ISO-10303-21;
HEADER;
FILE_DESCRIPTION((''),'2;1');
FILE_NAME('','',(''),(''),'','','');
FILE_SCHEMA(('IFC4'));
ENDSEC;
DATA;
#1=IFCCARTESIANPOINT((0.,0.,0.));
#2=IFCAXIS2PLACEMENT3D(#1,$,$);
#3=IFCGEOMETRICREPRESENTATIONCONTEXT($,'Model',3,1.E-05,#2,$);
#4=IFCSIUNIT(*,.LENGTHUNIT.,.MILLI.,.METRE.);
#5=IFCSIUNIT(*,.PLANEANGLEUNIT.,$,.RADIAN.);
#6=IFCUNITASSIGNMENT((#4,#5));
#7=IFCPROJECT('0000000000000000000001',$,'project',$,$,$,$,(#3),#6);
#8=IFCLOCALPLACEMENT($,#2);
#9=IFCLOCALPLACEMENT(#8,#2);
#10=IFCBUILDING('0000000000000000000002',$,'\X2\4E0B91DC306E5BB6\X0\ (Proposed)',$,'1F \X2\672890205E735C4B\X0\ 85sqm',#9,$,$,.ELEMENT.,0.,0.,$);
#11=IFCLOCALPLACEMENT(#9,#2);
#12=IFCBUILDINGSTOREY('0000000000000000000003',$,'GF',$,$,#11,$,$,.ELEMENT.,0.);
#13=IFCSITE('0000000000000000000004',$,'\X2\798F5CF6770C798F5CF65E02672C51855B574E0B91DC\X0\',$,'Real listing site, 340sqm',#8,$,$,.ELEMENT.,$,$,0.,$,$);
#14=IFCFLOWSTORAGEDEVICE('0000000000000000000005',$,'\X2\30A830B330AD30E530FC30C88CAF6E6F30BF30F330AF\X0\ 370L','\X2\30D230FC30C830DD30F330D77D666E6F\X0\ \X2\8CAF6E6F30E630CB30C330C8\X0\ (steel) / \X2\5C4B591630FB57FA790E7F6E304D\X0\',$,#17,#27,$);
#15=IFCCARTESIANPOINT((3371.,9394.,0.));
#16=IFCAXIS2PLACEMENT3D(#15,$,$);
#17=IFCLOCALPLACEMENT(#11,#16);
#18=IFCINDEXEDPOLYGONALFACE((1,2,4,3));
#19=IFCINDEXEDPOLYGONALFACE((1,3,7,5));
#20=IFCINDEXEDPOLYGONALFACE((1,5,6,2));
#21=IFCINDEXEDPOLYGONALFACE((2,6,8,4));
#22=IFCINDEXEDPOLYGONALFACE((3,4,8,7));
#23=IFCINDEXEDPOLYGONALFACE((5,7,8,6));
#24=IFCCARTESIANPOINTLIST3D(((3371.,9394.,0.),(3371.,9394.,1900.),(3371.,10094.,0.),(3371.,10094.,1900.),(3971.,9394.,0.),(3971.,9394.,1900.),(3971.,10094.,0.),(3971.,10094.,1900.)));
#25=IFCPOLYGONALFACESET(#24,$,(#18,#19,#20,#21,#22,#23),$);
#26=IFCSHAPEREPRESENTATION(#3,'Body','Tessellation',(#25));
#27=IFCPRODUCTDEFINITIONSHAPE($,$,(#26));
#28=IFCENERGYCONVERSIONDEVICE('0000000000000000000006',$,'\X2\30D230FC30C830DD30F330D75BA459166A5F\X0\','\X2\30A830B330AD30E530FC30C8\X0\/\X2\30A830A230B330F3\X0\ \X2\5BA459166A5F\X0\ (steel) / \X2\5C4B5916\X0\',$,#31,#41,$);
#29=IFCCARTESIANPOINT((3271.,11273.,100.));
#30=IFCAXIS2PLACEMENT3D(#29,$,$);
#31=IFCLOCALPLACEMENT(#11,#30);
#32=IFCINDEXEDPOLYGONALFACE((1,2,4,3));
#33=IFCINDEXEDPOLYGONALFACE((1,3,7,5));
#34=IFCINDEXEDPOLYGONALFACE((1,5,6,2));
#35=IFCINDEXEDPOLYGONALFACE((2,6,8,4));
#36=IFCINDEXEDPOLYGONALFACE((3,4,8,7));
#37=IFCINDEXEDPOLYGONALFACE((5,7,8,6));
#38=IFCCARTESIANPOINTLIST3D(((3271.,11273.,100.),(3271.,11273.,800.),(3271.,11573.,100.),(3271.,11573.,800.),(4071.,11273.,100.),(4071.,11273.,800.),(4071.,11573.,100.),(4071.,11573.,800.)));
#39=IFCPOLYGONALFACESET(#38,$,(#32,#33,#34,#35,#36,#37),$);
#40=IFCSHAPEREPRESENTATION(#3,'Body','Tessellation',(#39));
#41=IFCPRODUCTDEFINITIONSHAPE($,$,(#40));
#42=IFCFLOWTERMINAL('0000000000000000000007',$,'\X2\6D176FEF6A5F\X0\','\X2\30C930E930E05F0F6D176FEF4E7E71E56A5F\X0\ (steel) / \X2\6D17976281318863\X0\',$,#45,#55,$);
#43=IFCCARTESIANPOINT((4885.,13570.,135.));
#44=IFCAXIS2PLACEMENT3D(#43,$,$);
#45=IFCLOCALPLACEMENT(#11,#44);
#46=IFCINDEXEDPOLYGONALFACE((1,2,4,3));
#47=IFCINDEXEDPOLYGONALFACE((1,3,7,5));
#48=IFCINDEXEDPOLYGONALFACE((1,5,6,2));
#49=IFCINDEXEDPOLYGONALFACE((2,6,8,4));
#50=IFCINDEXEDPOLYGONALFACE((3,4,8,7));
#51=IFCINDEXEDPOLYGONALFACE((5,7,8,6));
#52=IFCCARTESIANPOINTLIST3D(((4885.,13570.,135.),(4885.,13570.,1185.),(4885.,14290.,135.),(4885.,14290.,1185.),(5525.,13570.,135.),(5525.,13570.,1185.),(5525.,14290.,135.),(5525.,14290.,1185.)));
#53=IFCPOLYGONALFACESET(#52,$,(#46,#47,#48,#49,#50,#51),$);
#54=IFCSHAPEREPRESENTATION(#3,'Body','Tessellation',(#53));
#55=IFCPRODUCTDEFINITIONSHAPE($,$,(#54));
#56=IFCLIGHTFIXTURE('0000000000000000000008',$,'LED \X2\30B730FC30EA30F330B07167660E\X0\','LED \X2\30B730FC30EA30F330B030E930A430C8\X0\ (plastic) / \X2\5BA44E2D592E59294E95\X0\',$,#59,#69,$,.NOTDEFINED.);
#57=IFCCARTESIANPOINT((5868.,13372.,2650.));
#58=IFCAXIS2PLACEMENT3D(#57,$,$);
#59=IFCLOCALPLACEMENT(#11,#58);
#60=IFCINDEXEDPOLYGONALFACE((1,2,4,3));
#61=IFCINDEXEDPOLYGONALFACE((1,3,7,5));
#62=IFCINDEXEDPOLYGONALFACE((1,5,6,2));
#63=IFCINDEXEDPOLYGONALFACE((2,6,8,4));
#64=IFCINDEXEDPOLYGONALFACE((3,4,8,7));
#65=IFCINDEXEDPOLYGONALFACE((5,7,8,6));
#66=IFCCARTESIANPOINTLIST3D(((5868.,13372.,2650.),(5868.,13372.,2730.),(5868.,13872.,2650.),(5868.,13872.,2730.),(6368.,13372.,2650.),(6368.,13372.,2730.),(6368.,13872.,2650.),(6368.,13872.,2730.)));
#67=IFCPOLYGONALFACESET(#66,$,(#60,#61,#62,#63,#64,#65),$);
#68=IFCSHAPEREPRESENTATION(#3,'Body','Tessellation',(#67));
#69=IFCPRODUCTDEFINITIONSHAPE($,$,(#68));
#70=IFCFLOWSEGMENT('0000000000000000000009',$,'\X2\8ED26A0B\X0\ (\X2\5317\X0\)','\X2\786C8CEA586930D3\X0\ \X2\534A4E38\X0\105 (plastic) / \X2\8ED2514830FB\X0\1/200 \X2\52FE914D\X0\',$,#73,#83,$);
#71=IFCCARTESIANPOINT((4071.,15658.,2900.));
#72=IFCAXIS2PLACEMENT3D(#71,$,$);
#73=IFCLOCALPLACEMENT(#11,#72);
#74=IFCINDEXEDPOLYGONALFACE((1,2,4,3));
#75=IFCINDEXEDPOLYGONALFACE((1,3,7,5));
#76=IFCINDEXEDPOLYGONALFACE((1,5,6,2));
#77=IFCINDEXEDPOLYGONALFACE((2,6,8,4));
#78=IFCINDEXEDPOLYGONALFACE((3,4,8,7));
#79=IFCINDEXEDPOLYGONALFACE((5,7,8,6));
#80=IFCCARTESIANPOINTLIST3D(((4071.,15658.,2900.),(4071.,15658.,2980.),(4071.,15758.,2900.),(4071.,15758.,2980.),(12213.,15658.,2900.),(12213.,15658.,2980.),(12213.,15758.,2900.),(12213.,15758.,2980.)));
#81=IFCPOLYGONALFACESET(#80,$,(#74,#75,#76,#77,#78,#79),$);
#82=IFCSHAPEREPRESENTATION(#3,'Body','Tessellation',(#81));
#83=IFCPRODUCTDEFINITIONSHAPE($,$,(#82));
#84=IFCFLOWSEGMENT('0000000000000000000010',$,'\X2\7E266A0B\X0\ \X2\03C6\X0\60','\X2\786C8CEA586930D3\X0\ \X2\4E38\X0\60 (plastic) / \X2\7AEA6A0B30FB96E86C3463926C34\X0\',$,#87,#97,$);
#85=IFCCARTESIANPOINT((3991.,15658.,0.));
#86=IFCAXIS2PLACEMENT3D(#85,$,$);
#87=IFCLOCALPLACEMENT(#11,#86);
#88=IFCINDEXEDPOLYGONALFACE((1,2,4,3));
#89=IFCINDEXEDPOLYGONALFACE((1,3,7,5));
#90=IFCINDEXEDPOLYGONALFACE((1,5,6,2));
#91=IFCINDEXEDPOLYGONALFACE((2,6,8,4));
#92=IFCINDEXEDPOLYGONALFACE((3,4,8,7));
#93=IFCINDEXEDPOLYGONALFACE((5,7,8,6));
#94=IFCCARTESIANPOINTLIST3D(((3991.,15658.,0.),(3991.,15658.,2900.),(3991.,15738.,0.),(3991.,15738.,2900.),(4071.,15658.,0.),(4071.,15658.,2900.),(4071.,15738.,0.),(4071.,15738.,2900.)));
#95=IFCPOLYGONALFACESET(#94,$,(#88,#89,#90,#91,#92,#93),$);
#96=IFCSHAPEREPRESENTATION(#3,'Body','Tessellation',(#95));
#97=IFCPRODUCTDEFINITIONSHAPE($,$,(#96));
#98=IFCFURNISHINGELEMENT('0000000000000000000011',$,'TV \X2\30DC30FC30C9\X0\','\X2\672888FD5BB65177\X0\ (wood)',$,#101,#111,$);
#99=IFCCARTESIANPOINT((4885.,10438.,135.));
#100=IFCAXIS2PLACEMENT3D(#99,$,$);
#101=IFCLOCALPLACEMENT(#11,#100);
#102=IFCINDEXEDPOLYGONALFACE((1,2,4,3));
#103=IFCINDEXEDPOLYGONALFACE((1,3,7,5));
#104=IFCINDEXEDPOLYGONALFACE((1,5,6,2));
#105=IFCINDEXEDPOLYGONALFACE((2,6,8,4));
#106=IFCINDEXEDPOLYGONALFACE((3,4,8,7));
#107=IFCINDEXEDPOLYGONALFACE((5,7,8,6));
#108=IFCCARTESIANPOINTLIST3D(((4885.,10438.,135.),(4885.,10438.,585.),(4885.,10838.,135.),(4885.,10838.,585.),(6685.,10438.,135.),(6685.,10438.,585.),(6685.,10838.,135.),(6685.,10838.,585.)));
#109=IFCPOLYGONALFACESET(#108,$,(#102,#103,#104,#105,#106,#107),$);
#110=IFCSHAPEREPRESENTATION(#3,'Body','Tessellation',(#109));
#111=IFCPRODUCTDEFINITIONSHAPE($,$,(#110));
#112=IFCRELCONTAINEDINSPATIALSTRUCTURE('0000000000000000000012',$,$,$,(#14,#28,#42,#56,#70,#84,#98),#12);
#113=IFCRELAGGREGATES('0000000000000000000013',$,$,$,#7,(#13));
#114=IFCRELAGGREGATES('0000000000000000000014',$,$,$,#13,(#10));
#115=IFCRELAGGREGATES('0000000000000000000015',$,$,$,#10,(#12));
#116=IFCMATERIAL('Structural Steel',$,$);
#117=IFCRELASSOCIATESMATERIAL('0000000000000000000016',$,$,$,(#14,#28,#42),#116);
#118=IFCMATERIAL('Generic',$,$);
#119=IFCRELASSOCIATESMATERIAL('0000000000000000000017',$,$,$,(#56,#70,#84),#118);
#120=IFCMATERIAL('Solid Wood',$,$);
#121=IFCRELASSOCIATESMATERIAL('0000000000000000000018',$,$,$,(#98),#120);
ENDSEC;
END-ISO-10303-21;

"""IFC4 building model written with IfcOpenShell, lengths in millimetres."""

from ifc_helpers import new_model, si_unit, frame, frame_2d, origin, place, context, project, spatial, rectangle, extrude, material, element, save


model = new_model("IFC4")

# Units and contexts
model_context = context("Model", 3, precision=1e-05, world=origin())
ifc_project = project(units=[si_unit("LENGTHUNIT", "METRE", prefix="MILLI"), si_unit("PLANEANGLEUNIT", "RADIAN")], contexts=[model_context])

# Site, building, storey
site_placement = place(None, origin())
site = spatial("IfcSite", under=ifc_project, at=site_placement, Name="福島県福島市本内字下釜", ObjectType="Real listing site, 340sqm", CompositionType="ELEMENT", RefElevation=0.0)
building_placement = place(site_placement, origin())
building = spatial("IfcBuilding", under=site, at=building_placement, Name="下釜の家 (Proposed)", ObjectType="1F 木造平屋 85sqm", CompositionType="ELEMENT", ElevationOfRefHeight=0.0, ElevationOfTerrain=0.0)
storey_placement = place(building_placement, origin())
storey = spatial("IfcBuildingStorey", under=building, at=storey_placement, Name="GF", CompositionType="ELEMENT", Elevation=0.0)

# Shared definitions
ifc_material_1 = material(Name="Solid Wood")

# Shared definitions
ifc_material_2 = material(Name="Structural Steel")

# Shared definitions
ifc_material_3 = material(Name="Generic")

# Flow storage device
flow_storage_device_placement = place(storey_placement, frame((3371.0, 9394.0, 0.0)))
element("IfcFlowStorageDevice", 1, at=flow_storage_device_placement, inside=storey, material=ifc_material_2, Name="エコキュート貯湯タンク 370L", Description="ヒートポンプ給湯 貯湯ユニット (steel) / 屋外・基礎置き", context=model_context, shape_type="SweptSolid", body=[
    extrude(rectangle(XDim=600.0, YDim=700.0, at=frame_2d((300.0, 350.0))), frame((3371.0, 9394.0, 0.0)), (0.0, 0.0, 1.0), 1900.0),
])

# Energy conversion device
energy_conversion_device_placement = place(storey_placement, frame((3271.0, 11273.0, 100.0)))
element("IfcEnergyConversionDevice", 2, at=energy_conversion_device_placement, inside=storey, material=ifc_material_2, Name="ヒートポンプ室外機", Description="エコキュート/エアコン 室外機 (steel) / 屋外", context=model_context, shape_type="SweptSolid", body=[
    extrude(rectangle(XDim=800.0, YDim=300.0, at=frame_2d((400.0, 150.0))), frame((3271.0, 11273.0, 100.0)), (0.0, 0.0, 1.0), 700.0),
])

# Flow terminal
flow_terminal_placement = place(storey_placement, frame((4885.0, 13570.0, 135.0)))
element("IfcFlowTerminal", 3, at=flow_terminal_placement, inside=storey, material=ifc_material_2, Name="洗濯機", Description="ドラム式洗濯乾燥機 (steel) / 洗面脱衣", context=model_context, shape_type="SweptSolid", body=[
    extrude(rectangle(XDim=640.0, YDim=720.0, at=frame_2d((320.0, 360.0))), frame((4885.0, 13570.0, 135.0)), (0.0, 0.0, 1.0), 1050.0),
])

# Light fixture
light_fixture_placement = place(storey_placement, frame((5868.0, 13372.0, 2650.0)))
element("IfcLightFixture", 4, at=light_fixture_placement, inside=storey, material=ifc_material_3, Name="LED シーリング照明", Description="LED シーリングライト (plastic) / 室中央天井", PredefinedType="NOTDEFINED", context=model_context, shape_type="SweptSolid", body=[
    extrude(rectangle(XDim=500.0, YDim=500.0, at=frame_2d((250.0, 250.0))), frame((5868.0, 13372.0, 2650.0)), (0.0, 0.0, 1.0), 80.0),
])

# Flow segments
flow_segment_1_placement = place(storey_placement, frame((4071.0, 15658.0, 2900.0)))
element("IfcFlowSegment", 5, at=flow_segment_1_placement, inside=storey, material=ifc_material_3, Name="軒樋 (北)", Description="硬質塩ビ 半丸105 (plastic) / 軒先・1/200 勾配", context=model_context, shape_type="SweptSolid", body=[
    extrude(rectangle(XDim=8142.0, YDim=100.0, at=frame_2d((4071.0, 50.0))), frame((4071.0, 15658.0, 2900.0)), (0.0, 0.0, 1.0), 80.0),
])
flow_segment_2_placement = place(storey_placement, frame((3991.0, 15658.0, 0.0)))
element("IfcFlowSegment", 6, at=flow_segment_2_placement, inside=storey, material=ifc_material_3, Name="縦樋 φ60", Description="硬質塩ビ 丸60 (plastic) / 竪樋・雨水排水", context=model_context, shape_type="SweptSolid", body=[
    extrude(rectangle(XDim=80.0, YDim=80.0, at=frame_2d((40.0, 40.0))), frame((3991.0, 15658.0, 0.0)), (0.0, 0.0, 1.0), 2900.0),
])

# Furnishing element
furnishing_placement = place(storey_placement, frame((4885.0, 10438.0, 135.0)))
element("IfcFurnishingElement", 7, at=furnishing_placement, inside=storey, material=ifc_material_1, Name="TV ボード", Description="木製家具 (wood)", context=model_context, shape_type="SweptSolid", body=[
    extrude(rectangle(XDim=1800.0, YDim=400.0, at=frame_2d((900.0, 200.0))), frame((4885.0, 10438.0, 135.0)), (0.0, 0.0, 1.0), 450.0),
])

save(model, "model.ifc")
